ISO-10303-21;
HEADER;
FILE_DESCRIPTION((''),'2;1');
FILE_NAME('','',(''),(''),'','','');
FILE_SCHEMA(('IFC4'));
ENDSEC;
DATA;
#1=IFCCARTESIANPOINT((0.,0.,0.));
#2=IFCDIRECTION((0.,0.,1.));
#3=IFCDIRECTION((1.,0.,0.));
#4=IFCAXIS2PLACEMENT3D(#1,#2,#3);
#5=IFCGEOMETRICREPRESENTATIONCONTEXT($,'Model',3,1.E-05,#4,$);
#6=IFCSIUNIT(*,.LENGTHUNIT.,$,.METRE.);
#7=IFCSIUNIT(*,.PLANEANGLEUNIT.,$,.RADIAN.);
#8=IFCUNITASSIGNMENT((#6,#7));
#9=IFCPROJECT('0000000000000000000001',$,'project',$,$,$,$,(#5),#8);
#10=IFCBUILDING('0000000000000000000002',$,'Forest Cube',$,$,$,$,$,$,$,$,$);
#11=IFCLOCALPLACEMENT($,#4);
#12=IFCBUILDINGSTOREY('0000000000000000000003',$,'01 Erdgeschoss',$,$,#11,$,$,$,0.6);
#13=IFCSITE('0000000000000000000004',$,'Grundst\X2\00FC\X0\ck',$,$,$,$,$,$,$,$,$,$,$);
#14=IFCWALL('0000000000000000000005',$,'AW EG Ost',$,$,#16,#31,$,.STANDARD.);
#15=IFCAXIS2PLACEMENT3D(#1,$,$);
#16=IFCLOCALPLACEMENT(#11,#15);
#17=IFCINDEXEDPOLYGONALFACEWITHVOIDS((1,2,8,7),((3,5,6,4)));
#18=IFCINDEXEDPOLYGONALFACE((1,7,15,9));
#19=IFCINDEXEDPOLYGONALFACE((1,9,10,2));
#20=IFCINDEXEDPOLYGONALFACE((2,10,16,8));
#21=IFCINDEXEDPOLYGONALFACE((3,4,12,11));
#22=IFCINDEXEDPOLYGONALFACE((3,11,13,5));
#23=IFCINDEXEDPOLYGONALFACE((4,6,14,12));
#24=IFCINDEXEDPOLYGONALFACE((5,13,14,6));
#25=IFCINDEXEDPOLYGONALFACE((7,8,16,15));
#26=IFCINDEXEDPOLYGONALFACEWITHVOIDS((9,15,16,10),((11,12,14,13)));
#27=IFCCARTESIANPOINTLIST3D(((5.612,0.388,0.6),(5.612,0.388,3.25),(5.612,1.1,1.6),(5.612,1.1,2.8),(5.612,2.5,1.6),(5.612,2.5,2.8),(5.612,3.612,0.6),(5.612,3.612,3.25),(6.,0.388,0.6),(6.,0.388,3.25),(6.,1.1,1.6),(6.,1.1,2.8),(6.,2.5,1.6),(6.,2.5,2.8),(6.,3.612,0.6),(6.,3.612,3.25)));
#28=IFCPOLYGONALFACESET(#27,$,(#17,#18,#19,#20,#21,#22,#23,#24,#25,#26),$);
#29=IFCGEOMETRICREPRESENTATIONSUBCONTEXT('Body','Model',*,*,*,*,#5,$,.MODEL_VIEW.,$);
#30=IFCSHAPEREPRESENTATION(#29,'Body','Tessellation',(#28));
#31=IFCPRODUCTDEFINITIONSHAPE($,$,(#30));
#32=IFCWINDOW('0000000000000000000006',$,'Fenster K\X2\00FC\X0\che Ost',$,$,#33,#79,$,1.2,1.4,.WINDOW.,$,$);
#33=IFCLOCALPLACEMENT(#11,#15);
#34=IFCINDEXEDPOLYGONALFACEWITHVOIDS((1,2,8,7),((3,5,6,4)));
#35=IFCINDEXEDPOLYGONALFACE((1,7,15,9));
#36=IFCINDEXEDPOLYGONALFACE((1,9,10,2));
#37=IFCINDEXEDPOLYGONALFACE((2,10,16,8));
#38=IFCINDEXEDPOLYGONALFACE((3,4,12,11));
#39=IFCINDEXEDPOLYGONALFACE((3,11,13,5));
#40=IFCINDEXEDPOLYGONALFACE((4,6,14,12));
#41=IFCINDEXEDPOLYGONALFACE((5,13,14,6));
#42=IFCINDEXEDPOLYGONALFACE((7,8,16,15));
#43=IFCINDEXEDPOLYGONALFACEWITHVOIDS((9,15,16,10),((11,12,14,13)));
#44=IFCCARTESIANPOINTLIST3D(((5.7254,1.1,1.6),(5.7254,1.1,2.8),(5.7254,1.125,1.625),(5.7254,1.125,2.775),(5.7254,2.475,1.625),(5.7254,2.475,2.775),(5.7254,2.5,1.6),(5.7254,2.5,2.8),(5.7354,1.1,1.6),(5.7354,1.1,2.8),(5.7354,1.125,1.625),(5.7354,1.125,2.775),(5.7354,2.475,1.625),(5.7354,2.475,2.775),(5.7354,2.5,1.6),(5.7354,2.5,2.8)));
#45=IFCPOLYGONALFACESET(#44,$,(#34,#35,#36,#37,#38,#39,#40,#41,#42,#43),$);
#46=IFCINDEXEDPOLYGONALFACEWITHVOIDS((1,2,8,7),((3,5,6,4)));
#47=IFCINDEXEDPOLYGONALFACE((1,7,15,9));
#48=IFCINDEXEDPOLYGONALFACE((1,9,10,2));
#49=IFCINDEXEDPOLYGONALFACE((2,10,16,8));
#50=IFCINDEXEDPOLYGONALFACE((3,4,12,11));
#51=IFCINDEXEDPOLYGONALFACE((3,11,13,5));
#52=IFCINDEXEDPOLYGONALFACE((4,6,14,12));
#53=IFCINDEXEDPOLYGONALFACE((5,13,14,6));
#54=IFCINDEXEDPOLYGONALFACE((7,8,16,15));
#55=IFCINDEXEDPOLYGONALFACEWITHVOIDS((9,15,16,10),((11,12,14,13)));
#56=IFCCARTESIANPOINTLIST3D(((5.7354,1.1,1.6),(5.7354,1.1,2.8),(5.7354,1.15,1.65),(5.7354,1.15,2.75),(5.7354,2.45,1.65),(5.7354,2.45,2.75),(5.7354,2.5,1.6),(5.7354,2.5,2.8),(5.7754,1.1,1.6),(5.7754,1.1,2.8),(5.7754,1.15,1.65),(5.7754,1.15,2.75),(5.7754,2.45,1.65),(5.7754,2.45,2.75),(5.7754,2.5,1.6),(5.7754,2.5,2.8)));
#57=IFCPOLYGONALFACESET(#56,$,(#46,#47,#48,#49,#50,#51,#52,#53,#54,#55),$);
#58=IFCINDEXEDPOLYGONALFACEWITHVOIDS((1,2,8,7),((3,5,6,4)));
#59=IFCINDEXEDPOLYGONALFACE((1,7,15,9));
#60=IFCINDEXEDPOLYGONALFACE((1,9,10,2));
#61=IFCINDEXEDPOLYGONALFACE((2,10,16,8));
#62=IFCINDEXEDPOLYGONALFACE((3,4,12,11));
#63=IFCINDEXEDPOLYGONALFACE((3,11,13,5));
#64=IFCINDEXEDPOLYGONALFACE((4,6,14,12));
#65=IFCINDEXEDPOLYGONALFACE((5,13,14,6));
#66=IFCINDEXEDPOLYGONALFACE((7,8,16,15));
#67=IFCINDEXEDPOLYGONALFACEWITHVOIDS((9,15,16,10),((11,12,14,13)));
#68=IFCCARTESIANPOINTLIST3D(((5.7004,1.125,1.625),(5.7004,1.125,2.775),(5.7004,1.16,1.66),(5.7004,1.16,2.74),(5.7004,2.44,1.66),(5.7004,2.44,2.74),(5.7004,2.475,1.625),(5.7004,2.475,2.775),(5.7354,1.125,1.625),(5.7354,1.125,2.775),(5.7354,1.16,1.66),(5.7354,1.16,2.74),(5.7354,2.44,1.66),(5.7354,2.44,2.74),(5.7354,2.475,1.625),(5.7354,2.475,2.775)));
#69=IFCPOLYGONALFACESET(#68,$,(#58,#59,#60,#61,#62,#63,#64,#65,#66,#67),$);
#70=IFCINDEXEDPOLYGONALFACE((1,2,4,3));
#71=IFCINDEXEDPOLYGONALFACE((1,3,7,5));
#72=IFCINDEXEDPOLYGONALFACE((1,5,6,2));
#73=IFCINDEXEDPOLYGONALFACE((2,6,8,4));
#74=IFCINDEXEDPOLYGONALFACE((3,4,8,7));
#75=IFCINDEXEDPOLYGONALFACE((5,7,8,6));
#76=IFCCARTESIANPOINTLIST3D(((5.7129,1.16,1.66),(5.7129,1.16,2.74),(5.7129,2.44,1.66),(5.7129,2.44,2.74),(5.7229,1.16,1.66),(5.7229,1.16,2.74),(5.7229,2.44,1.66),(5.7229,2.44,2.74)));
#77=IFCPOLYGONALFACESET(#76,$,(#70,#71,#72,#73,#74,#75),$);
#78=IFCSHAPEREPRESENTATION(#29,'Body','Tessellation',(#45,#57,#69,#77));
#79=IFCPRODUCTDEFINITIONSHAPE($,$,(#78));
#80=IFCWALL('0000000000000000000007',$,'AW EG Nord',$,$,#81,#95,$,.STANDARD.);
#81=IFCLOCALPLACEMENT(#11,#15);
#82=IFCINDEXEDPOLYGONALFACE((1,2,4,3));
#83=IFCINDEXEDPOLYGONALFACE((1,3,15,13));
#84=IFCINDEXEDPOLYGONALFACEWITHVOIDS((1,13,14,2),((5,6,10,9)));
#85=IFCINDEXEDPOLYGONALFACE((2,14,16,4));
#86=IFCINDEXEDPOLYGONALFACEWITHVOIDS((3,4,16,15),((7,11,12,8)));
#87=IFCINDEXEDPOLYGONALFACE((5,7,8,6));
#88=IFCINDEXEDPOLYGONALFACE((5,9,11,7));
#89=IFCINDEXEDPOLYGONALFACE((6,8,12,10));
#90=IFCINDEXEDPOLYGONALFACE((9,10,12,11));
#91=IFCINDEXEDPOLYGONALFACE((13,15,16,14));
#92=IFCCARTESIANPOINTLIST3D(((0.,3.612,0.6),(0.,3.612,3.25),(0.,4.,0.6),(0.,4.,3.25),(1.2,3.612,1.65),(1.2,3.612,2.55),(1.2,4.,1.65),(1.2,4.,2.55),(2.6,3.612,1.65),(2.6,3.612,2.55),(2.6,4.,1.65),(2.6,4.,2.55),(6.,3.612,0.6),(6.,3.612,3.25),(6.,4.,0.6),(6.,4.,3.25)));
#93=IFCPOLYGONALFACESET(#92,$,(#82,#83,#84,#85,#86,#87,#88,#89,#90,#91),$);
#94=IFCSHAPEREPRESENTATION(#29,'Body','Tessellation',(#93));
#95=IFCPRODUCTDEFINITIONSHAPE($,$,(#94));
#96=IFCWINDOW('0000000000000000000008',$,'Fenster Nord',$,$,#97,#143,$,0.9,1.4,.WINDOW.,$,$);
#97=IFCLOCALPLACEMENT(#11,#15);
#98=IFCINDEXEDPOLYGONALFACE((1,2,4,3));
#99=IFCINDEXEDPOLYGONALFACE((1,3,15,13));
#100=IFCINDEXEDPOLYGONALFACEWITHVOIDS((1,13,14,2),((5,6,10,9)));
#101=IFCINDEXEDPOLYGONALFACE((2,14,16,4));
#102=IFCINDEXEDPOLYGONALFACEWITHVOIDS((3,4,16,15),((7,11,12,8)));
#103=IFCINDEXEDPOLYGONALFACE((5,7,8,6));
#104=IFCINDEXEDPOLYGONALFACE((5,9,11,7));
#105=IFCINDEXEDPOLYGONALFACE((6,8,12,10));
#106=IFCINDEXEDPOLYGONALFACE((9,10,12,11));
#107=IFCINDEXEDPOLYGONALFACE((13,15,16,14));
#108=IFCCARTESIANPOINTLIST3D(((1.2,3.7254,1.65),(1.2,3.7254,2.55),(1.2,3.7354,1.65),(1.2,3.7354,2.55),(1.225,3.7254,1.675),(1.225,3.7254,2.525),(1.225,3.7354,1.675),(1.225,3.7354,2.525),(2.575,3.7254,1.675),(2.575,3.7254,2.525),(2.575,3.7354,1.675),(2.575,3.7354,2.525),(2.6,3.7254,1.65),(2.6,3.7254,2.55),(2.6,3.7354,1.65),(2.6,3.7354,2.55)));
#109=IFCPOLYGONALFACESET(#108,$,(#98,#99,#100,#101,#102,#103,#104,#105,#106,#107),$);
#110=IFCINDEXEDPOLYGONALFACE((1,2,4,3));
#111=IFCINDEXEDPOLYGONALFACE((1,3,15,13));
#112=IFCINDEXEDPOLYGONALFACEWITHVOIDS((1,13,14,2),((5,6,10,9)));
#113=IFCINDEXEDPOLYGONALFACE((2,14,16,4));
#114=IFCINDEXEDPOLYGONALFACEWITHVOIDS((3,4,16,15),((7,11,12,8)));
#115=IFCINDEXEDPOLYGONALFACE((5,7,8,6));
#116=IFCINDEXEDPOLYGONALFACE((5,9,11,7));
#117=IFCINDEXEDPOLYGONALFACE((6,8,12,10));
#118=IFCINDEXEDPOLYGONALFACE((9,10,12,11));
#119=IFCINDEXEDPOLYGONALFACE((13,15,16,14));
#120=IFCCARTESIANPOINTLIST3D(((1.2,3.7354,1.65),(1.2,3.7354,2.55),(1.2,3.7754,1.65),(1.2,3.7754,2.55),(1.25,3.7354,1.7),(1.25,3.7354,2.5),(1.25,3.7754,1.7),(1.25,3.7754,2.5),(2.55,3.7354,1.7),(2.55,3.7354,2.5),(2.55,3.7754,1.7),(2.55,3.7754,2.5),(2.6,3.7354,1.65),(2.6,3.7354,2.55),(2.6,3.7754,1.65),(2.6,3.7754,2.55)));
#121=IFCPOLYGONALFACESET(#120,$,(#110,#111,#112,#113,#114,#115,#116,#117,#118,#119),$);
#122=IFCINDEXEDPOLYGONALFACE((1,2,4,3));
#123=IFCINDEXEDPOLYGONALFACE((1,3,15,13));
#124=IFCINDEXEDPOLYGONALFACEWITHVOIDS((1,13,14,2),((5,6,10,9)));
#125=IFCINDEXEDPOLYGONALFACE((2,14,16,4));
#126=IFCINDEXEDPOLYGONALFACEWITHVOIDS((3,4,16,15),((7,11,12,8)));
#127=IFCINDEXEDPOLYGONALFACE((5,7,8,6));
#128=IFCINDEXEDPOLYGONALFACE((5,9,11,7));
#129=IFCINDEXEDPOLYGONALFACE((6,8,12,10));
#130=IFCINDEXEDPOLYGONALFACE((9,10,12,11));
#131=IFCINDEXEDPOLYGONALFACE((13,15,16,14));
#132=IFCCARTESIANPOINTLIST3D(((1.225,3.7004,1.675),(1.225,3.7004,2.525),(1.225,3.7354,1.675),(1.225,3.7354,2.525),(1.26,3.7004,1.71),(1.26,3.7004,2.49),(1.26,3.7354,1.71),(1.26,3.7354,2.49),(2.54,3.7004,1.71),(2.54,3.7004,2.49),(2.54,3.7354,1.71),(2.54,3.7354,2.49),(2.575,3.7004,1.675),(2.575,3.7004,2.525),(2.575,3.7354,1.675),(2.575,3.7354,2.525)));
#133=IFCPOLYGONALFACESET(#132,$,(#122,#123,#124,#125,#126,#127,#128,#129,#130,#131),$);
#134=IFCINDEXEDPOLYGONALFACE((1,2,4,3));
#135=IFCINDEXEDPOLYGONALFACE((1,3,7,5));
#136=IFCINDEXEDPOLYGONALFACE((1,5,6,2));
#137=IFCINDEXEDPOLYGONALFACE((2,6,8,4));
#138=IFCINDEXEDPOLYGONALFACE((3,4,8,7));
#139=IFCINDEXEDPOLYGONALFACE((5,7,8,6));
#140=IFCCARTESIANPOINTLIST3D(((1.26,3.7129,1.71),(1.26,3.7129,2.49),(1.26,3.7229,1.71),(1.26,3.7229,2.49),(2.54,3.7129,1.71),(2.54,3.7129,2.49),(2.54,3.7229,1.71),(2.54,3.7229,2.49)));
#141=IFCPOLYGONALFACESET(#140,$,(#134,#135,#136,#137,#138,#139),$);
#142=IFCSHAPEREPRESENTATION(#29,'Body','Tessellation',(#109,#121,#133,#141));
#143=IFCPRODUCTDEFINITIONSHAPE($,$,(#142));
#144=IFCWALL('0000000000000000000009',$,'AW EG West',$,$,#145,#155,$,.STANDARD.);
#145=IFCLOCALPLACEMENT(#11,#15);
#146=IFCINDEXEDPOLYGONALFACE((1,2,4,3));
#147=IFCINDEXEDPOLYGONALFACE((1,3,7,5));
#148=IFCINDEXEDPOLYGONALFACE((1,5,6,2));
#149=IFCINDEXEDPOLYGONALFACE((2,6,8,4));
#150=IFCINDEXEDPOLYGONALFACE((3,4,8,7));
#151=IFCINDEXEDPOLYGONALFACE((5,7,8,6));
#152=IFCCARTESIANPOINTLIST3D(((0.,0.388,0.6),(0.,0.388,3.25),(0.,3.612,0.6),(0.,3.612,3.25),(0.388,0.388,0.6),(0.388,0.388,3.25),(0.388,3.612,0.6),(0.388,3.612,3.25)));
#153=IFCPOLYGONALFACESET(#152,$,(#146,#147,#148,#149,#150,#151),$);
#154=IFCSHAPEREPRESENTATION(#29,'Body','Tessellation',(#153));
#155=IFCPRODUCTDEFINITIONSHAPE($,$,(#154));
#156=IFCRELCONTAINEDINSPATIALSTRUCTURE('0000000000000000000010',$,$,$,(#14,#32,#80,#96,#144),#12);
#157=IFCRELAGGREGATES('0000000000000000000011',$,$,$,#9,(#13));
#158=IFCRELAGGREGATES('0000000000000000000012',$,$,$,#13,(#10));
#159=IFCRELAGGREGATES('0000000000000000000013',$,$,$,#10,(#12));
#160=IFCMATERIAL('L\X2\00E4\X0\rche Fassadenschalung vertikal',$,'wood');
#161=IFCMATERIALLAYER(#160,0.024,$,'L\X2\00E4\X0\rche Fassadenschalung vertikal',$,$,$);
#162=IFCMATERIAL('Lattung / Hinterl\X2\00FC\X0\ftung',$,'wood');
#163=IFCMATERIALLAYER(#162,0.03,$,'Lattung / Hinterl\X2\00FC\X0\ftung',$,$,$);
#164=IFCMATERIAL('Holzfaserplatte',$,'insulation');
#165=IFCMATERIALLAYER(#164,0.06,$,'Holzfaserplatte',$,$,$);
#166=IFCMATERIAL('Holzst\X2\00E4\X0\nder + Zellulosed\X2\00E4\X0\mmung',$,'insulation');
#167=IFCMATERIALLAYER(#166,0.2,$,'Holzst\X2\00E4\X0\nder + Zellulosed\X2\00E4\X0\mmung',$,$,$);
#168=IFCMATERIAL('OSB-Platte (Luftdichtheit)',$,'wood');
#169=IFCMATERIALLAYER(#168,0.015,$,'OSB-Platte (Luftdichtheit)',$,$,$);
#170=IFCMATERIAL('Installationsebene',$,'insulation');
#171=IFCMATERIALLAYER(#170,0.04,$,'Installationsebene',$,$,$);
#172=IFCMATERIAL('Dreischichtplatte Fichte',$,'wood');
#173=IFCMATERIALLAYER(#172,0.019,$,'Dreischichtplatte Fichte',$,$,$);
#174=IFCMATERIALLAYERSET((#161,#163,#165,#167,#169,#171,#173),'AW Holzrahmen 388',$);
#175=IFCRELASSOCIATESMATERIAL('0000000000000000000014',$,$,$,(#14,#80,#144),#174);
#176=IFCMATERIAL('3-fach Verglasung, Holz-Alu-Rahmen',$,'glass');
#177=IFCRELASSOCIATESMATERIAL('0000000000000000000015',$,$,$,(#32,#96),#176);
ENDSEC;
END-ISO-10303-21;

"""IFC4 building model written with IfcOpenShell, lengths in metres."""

from ifc_helpers import new_model, si_unit, frame, origin_with_axes, place, context, subcontext, project, spatial, line, indexed_curve, outline, extrude, material, layer, layer_set, element, fill, save


model = new_model("IFC4")

# Units and contexts
model_context = context("Model", 3, precision=1e-05, world=origin_with_axes())
body_context = subcontext(model_context, "Body", "Model", "MODEL_VIEW")
ifc_project = project(units=[si_unit("LENGTHUNIT", "METRE"), si_unit("PLANEANGLEUNIT", "RADIAN")], contexts=[model_context])

# Site, building, storey
site = spatial("IfcSite", under=ifc_project, Name="Grundstück")
building = spatial("IfcBuilding", under=site, Name="Forest Cube")
storey_placement = place(None, origin_with_axes())
storey = spatial("IfcBuildingStorey", under=building, at=storey_placement, Name="01 Erdgeschoss", Elevation=0.6)

# Shared definitions
ifc_material_1 = material(Name="Lärche Fassadenschalung vertikal", Category="wood")
ifc_layer_1 = layer(ifc_material_1, 0.024, Name="Lärche Fassadenschalung vertikal")
ifc_material_2 = material(Name="Lattung / Hinterlüftung", Category="wood")
ifc_layer_2 = layer(ifc_material_2, 0.03, Name="Lattung / Hinterlüftung")
ifc_material_3 = material(Name="Holzfaserplatte", Category="insulation")
ifc_layer_3 = layer(ifc_material_3, 0.06, Name="Holzfaserplatte")
ifc_material_4 = material(Name="Holzständer + Zellulosedämmung", Category="insulation")
ifc_layer_4 = layer(ifc_material_4, 0.2, Name="Holzständer + Zellulosedämmung")
ifc_material_5 = material(Name="OSB-Platte (Luftdichtheit)", Category="wood")
ifc_layer_5 = layer(ifc_material_5, 0.015, Name="OSB-Platte (Luftdichtheit)")
ifc_material_6 = material(Name="Installationsebene", Category="insulation")
ifc_layer_6 = layer(ifc_material_6, 0.04, Name="Installationsebene")
ifc_material_7 = material(Name="Dreischichtplatte Fichte", Category="wood")
ifc_layer_7 = layer(ifc_material_7, 0.019, Name="Dreischichtplatte Fichte")
ifc_layer_set_1 = layer_set([ifc_layer_1, ifc_layer_2, ifc_layer_3, ifc_layer_4, ifc_layer_5, ifc_layer_6, ifc_layer_7], Name="AW Holzrahmen 388")
ifc_material_8 = material(Name="3-fach Verglasung, Holz-Alu-Rahmen", Category="glass")

# Walls, openings, windows
wall_1_placement = place(storey_placement, frame((6.0, 0.388, 0.6), z_axis=(0.0, 0.0, 1.0), x_axis=(0.0, 1.0, 0.0)))
wall_1 = element("IfcWall", 1, at=wall_1_placement, inside=storey, material=ifc_layer_set_1, Name="AW EG Ost", PredefinedType="STANDARD", context=body_context, shape_type="SweptSolid", body=[
    extrude(outline(indexed_curve([(0.0, 0.0), (0.0, 0.388), (3.224, 0.388), (3.224, 0.0), (0.0, 0.0)], self_intersect=False)), origin_with_axes(), (0.0, 0.0, 1.0), 2.65),
])
opening_1_placement = place(wall_1_placement, frame((0.712, -0.1, 1.0), z_axis=(0.0, 0.0, 1.0), x_axis=(1.0, 0.0, 0.0)))
opening_1 = element("IfcOpeningElement", 2, at=opening_1_placement, cuts=wall_1, context=body_context, shape_type="SweptSolid", body=[
    extrude(outline(indexed_curve([(0.0, 0.0), (0.0, 0.588), (1.4, 0.588), (1.4, 0.0), (0.0, 0.0)], self_intersect=False)), origin_with_axes(), (0.0, 0.0, 1.0), 1.2),
])
window_1_placement = place(storey_placement, frame((5.8254, 1.1, 1.6), z_axis=(0.0, 0.0, 1.0), x_axis=(0.0, 1.0, 0.0)))
window_1 = element("IfcWindow", 3, at=window_1_placement, inside=storey, material=ifc_material_8, Name="Fenster Küche Ost", OverallHeight=1.2, OverallWidth=1.4, PredefinedType="WINDOW", context=body_context, shape_type="SweptSolid", body=[
    extrude(outline(indexed_curve([(0.0, 0.0), (1.4, 0.0), (1.4, 1.2), (0.0, 1.2)], segments=[line(1, 2, 3, 4, 1)]), holes=[indexed_curve([(0.025, 0.025), (1.375, 0.025), (1.375, 1.175), (0.025, 1.175)], segments=[line(1, 2, 3, 4, 1)])]), frame((0.0, 0.09, 0.0), z_axis=(0.0, -1.0, 0.0), x_axis=(1.0, 0.0, 0.0)), (0.0, 0.0, -1.0), 0.01),
    extrude(outline(indexed_curve([(0.0, 0.0), (1.4, 0.0), (1.4, 1.2), (0.0, 1.2)], segments=[line(1, 2, 3, 4, 1)]), holes=[indexed_curve([(0.05, 0.05), (1.35, 0.05), (1.35, 1.15), (0.05, 1.15)], segments=[line(1, 2, 3, 4, 1)])]), frame((0.0, 0.05, 0.0), z_axis=(0.0, -1.0, 0.0), x_axis=(1.0, 0.0, 0.0)), (0.0, 0.0, -1.0), 0.04),
    extrude(outline(indexed_curve([(0.0, 0.0), (1.35, 0.0), (1.35, 1.15), (0.0, 1.15)], segments=[line(1, 2, 3, 4, 1)]), holes=[indexed_curve([(0.035, 0.035), (1.315, 0.035), (1.315, 1.115), (0.035, 1.115)], segments=[line(1, 2, 3, 4, 1)])]), frame((0.025, 0.09, 0.025), z_axis=(0.0, -1.0, 0.0), x_axis=(1.0, 0.0, 0.0)), (0.0, 0.0, -1.0), 0.035),
    extrude(outline(indexed_curve([(0.035, 0.035), (1.315, 0.035), (1.315, 1.115), (0.035, 1.115)], segments=[line(1, 2, 3, 4, 1)])), frame((0.025, 0.1025, 0.025), z_axis=(0.0, -1.0, 0.0), x_axis=(1.0, 0.0, 0.0)), (0.0, 0.0, -1.0), 0.01),
])
fill(opening_1, window_1)
wall_2_placement = place(storey_placement, frame((6.0, 4.0, 0.6), z_axis=(0.0, 0.0, 1.0), x_axis=(-1.0, 0.0, 0.0)))
wall_2 = element("IfcWall", 4, at=wall_2_placement, inside=storey, material=ifc_layer_set_1, Name="AW EG Nord", PredefinedType="STANDARD", context=body_context, shape_type="SweptSolid", body=[
    extrude(outline(indexed_curve([(0.0, 0.0), (0.0, 0.388), (6.0, 0.388), (6.0, 0.0), (0.0, 0.0)], self_intersect=False)), origin_with_axes(), (0.0, 0.0, 1.0), 2.65),
])
opening_2_placement = place(wall_2_placement, frame((3.4, -0.1, 1.05), z_axis=(0.0, 0.0, 1.0), x_axis=(1.0, 0.0, 0.0)))
opening_2 = element("IfcOpeningElement", 5, at=opening_2_placement, cuts=wall_2, context=body_context, shape_type="SweptSolid", body=[
    extrude(outline(indexed_curve([(0.0, 0.0), (0.0, 0.588), (1.4, 0.588), (1.4, 0.0), (0.0, 0.0)], self_intersect=False)), origin_with_axes(), (0.0, 0.0, 1.0), 0.9),
])
window_2_placement = place(storey_placement, frame((2.6, 3.8254, 1.65), z_axis=(0.0, 0.0, 1.0), x_axis=(-1.0, 0.0, 0.0)))
window_2 = element("IfcWindow", 6, at=window_2_placement, inside=storey, material=ifc_material_8, Name="Fenster Nord", OverallHeight=0.9, OverallWidth=1.4, PredefinedType="WINDOW", context=body_context, shape_type="SweptSolid", body=[
    extrude(outline(indexed_curve([(0.0, 0.0), (1.4, 0.0), (1.4, 0.9), (0.0, 0.9)], segments=[line(1, 2, 3, 4, 1)]), holes=[indexed_curve([(0.025, 0.025), (1.375, 0.025), (1.375, 0.875), (0.025, 0.875)], segments=[line(1, 2, 3, 4, 1)])]), frame((0.0, 0.09, 0.0), z_axis=(0.0, -1.0, 0.0), x_axis=(1.0, 0.0, 0.0)), (0.0, 0.0, -1.0), 0.01),
    extrude(outline(indexed_curve([(0.0, 0.0), (1.4, 0.0), (1.4, 0.9), (0.0, 0.9)], segments=[line(1, 2, 3, 4, 1)]), holes=[indexed_curve([(0.05, 0.05), (1.35, 0.05), (1.35, 0.85), (0.05, 0.85)], segments=[line(1, 2, 3, 4, 1)])]), frame((0.0, 0.05, 0.0), z_axis=(0.0, -1.0, 0.0), x_axis=(1.0, 0.0, 0.0)), (0.0, 0.0, -1.0), 0.04),
    extrude(outline(indexed_curve([(0.0, 0.0), (1.35, 0.0), (1.35, 0.85), (0.0, 0.85)], segments=[line(1, 2, 3, 4, 1)]), holes=[indexed_curve([(0.035, 0.035), (1.315, 0.035), (1.315, 0.815), (0.035, 0.815)], segments=[line(1, 2, 3, 4, 1)])]), frame((0.025, 0.09, 0.025), z_axis=(0.0, -1.0, 0.0), x_axis=(1.0, 0.0, 0.0)), (0.0, 0.0, -1.0), 0.035),
    extrude(outline(indexed_curve([(0.035, 0.035), (1.315, 0.035), (1.315, 0.815), (0.035, 0.815)], segments=[line(1, 2, 3, 4, 1)])), frame((0.025, 0.1025, 0.025), z_axis=(0.0, -1.0, 0.0), x_axis=(1.0, 0.0, 0.0)), (0.0, 0.0, -1.0), 0.01),
])
fill(opening_2, window_2)

# Wall
wall_3_placement = place(storey_placement, frame((0.0, 3.612, 0.6), z_axis=(0.0, 0.0, 1.0), x_axis=(0.0, -1.0, 0.0)))
element("IfcWall", 7, at=wall_3_placement, inside=storey, material=ifc_layer_set_1, Name="AW EG West", PredefinedType="STANDARD", context=body_context, shape_type="SweptSolid", body=[
    extrude(outline(indexed_curve([(0.0, 0.0), (0.0, 0.388), (3.224, 0.388), (3.224, 0.0), (0.0, 0.0)], self_intersect=False)), origin_with_axes(), (0.0, 0.0, 1.0), 2.65),
])

save(model, "model.ifc")
